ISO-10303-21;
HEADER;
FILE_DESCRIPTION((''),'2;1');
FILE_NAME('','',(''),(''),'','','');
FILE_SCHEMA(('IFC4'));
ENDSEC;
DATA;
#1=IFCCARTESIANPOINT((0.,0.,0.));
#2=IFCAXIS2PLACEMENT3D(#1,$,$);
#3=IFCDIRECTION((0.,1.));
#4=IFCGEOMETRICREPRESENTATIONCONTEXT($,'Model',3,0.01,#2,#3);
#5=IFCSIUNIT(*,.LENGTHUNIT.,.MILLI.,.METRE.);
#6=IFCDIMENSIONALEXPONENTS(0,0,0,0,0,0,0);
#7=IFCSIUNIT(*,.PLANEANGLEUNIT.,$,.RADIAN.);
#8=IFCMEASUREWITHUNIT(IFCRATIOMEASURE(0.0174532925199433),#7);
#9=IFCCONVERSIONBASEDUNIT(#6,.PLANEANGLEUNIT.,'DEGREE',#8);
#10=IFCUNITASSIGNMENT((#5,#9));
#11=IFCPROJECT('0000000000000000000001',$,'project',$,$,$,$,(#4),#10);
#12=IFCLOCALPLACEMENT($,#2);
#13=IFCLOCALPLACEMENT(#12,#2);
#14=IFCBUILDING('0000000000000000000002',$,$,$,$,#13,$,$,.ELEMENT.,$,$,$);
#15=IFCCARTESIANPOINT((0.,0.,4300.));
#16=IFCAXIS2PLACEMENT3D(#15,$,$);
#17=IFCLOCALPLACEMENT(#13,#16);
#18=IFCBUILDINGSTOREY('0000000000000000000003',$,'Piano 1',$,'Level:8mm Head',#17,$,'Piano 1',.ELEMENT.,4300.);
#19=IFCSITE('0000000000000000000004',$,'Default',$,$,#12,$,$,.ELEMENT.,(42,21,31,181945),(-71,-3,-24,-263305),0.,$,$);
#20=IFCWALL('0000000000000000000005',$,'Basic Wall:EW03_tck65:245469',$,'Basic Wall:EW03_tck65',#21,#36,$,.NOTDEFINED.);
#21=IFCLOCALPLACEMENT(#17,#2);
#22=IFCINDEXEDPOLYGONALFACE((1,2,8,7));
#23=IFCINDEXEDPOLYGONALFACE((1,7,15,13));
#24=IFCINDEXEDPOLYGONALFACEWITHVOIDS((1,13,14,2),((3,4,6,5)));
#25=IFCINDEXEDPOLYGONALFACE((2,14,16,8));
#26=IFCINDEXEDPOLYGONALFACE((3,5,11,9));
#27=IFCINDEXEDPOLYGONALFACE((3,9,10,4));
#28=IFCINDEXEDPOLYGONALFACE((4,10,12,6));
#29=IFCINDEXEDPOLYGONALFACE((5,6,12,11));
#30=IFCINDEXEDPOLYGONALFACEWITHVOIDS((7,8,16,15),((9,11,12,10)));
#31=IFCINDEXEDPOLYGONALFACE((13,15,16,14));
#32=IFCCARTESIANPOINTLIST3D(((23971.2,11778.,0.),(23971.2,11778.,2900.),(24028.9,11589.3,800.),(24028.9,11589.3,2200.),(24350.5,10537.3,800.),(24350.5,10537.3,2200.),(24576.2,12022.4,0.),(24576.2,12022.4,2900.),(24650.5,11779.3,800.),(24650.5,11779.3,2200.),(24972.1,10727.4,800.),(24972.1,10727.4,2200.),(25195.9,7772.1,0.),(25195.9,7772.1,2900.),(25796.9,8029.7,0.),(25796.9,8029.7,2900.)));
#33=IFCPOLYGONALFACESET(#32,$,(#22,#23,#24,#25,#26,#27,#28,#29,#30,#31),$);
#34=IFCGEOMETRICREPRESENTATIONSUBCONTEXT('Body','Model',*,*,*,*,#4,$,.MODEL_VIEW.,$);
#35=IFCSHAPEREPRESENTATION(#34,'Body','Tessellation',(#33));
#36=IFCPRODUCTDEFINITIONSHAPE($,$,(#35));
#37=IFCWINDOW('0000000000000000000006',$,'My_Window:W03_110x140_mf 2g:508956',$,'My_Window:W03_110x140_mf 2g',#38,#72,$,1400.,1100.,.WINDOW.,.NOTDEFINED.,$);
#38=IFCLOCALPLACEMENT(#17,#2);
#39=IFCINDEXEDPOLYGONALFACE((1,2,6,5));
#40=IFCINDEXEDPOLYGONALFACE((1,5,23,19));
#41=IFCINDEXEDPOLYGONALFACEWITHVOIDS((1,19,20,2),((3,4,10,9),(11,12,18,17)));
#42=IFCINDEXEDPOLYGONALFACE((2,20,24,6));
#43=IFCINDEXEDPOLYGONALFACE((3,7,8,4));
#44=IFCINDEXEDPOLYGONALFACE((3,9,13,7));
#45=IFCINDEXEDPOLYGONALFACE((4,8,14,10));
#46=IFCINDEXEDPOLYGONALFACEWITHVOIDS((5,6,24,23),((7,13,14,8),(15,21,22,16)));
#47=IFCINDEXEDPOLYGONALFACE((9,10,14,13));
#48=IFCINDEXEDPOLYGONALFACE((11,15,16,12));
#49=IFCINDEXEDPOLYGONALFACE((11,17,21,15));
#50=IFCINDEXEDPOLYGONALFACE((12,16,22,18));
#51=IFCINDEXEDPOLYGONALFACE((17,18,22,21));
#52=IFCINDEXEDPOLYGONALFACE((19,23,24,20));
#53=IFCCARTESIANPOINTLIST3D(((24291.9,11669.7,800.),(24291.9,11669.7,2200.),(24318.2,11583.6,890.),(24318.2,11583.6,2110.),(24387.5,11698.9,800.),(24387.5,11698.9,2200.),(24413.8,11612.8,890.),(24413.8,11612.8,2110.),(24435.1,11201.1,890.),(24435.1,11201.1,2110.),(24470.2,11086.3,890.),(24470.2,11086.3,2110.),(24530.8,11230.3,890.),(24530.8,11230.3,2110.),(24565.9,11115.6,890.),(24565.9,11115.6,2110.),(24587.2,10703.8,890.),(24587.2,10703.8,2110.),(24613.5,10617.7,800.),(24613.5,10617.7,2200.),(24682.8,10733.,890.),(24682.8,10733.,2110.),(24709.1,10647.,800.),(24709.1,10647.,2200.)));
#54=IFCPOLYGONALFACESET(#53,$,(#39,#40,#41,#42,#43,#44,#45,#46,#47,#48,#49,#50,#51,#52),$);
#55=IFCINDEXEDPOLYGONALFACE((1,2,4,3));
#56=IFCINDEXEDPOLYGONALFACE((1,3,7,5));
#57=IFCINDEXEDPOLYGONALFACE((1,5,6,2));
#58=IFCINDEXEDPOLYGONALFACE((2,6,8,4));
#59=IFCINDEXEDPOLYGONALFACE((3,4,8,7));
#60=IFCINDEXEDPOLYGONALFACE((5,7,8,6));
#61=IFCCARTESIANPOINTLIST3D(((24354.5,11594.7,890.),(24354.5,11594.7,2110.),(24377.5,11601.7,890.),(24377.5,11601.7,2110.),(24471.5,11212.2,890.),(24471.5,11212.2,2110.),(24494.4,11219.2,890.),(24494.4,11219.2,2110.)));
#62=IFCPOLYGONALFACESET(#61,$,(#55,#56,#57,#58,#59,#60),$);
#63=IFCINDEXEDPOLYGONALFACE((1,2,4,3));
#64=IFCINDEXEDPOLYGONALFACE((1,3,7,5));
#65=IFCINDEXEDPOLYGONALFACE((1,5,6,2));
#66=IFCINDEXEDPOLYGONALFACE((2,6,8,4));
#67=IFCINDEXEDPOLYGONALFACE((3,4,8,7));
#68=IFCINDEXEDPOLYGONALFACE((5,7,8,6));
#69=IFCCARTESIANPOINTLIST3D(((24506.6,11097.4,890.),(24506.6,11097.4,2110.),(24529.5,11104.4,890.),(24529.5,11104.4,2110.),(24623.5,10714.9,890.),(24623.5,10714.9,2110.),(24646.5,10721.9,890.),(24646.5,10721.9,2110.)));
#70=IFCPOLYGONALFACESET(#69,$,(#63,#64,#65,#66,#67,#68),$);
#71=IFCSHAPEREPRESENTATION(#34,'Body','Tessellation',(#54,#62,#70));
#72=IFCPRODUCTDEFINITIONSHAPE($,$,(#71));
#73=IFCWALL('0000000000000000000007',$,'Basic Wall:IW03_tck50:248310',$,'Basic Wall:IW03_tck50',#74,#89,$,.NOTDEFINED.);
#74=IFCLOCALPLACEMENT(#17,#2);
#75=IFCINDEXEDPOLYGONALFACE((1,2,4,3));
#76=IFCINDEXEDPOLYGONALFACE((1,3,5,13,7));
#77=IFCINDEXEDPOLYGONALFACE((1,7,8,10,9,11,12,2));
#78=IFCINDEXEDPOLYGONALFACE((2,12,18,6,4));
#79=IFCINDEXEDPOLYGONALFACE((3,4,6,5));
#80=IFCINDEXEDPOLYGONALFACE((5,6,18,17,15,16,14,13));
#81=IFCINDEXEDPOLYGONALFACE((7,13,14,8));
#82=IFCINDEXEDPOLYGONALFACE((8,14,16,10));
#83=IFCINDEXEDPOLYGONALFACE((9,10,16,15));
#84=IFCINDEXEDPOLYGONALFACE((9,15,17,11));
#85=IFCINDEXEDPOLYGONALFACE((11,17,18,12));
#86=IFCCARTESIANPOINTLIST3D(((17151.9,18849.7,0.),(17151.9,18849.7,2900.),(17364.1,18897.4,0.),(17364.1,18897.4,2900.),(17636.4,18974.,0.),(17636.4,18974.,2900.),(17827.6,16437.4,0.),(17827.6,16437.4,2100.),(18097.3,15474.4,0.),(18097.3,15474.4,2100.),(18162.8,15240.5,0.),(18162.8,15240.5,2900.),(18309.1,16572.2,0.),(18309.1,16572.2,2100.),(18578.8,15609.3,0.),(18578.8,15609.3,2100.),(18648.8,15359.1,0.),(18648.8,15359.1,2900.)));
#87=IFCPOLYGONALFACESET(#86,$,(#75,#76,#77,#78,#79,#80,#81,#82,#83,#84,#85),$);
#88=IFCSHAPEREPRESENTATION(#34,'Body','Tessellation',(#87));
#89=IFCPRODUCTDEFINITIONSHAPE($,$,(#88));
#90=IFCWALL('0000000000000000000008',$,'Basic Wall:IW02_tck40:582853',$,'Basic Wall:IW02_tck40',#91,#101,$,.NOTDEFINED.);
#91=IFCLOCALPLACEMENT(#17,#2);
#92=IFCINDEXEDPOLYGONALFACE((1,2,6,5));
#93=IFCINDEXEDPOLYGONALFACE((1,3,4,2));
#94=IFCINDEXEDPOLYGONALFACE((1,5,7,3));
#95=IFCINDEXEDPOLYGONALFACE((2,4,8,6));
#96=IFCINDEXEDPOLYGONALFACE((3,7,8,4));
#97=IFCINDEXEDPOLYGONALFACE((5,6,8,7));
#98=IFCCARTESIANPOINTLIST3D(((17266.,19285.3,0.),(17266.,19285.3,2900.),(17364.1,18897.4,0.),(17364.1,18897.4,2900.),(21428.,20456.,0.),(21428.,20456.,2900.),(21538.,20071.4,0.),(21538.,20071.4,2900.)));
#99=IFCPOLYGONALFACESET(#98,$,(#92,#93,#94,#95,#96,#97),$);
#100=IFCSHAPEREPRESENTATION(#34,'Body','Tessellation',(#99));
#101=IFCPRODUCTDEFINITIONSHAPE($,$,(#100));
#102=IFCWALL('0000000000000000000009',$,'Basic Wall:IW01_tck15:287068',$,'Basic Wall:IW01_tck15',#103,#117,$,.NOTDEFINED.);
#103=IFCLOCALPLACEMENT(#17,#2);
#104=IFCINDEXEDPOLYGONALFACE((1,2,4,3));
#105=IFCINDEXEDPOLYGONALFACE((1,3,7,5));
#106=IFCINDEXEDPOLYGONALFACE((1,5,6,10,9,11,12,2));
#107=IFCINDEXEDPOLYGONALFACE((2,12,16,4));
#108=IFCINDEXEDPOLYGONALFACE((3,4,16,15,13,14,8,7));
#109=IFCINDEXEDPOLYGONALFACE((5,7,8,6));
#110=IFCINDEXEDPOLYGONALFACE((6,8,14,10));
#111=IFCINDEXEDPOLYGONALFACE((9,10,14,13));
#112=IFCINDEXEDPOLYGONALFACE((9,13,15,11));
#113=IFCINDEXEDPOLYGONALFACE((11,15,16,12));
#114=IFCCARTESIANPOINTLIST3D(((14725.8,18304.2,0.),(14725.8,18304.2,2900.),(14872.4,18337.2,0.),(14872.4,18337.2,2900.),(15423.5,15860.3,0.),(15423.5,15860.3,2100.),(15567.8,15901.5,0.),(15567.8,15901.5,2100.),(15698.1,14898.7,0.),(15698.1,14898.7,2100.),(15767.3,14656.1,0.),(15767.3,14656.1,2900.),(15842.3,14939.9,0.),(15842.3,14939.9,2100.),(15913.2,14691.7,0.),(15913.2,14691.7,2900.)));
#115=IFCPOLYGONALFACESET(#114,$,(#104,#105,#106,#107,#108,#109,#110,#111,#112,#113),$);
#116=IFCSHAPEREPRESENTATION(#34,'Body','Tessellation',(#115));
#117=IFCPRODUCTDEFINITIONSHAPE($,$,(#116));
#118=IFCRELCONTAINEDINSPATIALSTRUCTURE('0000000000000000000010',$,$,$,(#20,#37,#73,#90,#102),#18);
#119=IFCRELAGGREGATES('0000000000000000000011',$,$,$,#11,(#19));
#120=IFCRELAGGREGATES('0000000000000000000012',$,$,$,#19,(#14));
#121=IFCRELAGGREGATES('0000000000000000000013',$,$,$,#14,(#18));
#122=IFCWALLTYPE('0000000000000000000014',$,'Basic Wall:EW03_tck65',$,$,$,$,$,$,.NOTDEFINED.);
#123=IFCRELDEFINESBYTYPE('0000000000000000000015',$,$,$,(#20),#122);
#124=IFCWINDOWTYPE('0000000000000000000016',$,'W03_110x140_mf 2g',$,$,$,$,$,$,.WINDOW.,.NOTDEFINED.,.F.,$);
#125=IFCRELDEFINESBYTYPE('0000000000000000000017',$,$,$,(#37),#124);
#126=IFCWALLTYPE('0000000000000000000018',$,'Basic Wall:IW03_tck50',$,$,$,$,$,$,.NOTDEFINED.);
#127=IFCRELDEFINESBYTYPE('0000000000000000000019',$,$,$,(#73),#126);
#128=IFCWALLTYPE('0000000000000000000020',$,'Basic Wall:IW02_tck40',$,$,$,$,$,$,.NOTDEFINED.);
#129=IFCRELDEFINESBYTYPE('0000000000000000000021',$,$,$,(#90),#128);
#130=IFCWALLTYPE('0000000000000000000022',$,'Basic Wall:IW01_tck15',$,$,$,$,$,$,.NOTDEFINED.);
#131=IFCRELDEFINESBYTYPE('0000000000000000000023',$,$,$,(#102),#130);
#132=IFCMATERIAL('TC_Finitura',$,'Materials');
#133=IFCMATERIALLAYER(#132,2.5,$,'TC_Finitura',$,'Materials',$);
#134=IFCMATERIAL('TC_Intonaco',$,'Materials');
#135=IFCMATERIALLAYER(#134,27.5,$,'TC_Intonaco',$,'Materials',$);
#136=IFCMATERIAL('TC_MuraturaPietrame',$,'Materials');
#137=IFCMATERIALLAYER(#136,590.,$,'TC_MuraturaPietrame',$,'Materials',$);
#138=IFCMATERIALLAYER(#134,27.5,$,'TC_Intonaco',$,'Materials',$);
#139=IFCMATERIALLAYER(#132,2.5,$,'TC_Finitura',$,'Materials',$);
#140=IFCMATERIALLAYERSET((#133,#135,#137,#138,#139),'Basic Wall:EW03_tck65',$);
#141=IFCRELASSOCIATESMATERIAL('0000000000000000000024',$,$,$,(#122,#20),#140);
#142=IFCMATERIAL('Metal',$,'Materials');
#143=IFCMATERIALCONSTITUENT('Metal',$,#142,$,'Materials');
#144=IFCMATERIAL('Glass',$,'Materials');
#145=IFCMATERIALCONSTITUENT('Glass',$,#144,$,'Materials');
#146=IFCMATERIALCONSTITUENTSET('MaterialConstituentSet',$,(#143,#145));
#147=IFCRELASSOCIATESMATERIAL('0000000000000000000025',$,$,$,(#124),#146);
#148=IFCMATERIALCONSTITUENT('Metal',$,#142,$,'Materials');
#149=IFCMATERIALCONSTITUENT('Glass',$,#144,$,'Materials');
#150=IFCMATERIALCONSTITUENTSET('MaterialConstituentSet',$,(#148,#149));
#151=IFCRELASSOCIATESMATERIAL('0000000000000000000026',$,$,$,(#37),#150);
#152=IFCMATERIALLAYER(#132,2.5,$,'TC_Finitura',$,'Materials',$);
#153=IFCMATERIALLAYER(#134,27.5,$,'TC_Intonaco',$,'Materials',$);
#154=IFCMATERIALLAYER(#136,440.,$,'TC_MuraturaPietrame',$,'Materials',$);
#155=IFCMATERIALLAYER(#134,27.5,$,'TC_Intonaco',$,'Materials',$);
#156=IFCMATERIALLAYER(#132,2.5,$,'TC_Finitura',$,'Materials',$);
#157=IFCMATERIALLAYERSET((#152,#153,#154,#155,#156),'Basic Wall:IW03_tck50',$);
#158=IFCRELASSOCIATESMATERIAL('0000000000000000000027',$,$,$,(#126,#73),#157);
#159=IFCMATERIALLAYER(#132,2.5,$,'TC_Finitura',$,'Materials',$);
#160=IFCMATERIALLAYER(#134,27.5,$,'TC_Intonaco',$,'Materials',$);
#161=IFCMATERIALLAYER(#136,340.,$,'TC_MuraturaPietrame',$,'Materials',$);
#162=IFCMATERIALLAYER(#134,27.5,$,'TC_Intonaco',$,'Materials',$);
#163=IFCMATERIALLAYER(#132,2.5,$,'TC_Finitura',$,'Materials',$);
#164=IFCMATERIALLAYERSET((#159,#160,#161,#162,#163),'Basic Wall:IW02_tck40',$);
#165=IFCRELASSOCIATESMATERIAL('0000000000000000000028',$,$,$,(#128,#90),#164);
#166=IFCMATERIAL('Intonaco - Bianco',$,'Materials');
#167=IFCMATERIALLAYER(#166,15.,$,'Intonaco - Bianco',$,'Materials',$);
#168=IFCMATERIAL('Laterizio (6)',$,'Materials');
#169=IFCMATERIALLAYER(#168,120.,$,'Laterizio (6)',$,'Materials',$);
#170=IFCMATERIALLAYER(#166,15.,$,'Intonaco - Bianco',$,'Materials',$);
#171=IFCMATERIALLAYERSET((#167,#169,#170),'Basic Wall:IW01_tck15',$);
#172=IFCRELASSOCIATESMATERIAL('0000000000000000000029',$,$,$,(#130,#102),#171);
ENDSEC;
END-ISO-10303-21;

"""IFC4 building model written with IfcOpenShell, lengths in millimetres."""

from ifc_helpers import new_model, entity, si_unit, converted_unit, direction, frame, frame_2d, origin, origin_2d_with_axis, place, context, subcontext, project, spatial, polyline, rectangle, outline, extrude, clip, bounded_halfspace, source, transform, mapped, material, layer, layer_set, layer_usage, constituent, constituent_set, type_object, type_shapes, element, fill, save


model = new_model("IFC4")

# Units and contexts
model_context = context("Model", 3, precision=0.01, world=origin(), true_north=direction((0.0, 1.0)))
body_context = subcontext(model_context, "Body", "Model", "MODEL_VIEW")
ifc_project = project(units=[si_unit("LENGTHUNIT", "METRE", prefix="MILLI"), converted_unit("PLANEANGLEUNIT", "DEGREE", entity("IfcRatioMeasure", 0.0174532925199433), si_unit("PLANEANGLEUNIT", "RADIAN"), dimensions=[0, 0, 0, 0, 0, 0, 0])], contexts=[model_context])

# Site, building, storey
site_placement = place(None, origin())
site = spatial("IfcSite", under=ifc_project, at=site_placement, Name="Default", CompositionType="ELEMENT", RefLatitude=(42, 21, 31, 181945), RefLongitude=(-71, -3, -24, -263305), RefElevation=0.0)
building_placement = place(site_placement, origin())
building = spatial("IfcBuilding", under=site, at=building_placement, CompositionType="ELEMENT")
storey_placement = place(building_placement, frame((0.0, 0.0, 4300.0)))
storey = spatial("IfcBuildingStorey", under=building, at=storey_placement, Name="Piano 1", ObjectType="Level:8mm Head", LongName="Piano 1", CompositionType="ELEMENT", Elevation=4300.0)

# Shared definitions
ifc_material_1 = material(Name="TC_Finitura", Category="Materials")
ifc_material_2 = material(Name="TC_Intonaco", Category="Materials")
ifc_material_3 = material(Name="TC_MuraturaPietrame", Category="Materials")

# Wall, opening, window
ifc_material_4 = material(Name="Metal", Category="Materials")
ifc_material_5 = material(Name="Glass", Category="Materials")
ifc_layer_1 = layer(ifc_material_1, 2.5, Name="TC_Finitura", Category="Materials")
ifc_layer_2 = layer(ifc_material_2, 27.5, Name="TC_Intonaco", Category="Materials")
ifc_layer_3 = layer(ifc_material_3, 590.0, Name="TC_MuraturaPietrame", Category="Materials")
ifc_layer_4 = layer(ifc_material_2, 27.5, Name="TC_Intonaco", Category="Materials")
ifc_layer_5 = layer(ifc_material_1, 2.5, Name="TC_Finitura", Category="Materials")
ifc_layer_set_1 = layer_set([ifc_layer_1, ifc_layer_2, ifc_layer_3, ifc_layer_4, ifc_layer_5], Name="Basic Wall:EW03_tck65")
ifc_layer_usage_1 = layer_usage(ifc_layer_set_1, "AXIS2", "NEGATIVE", 325.0)
wall_type_1 = type_object("IfcWallType", Name="Basic Wall:EW03_tck65", PredefinedType="NOTDEFINED", material=ifc_layer_set_1)
wall_1_placement = place(storey_placement, frame((24265.4, 11927.4, 0.0), z_axis=(0.0, 0.0, 1.0), x_axis=(0.292372, -0.956305, 0.0)))
wall_1 = element("IfcWall", 1, at=wall_1_placement, inside=storey, type_object=wall_type_1, material=ifc_layer_usage_1, Name="Basic Wall:EW03_tck65:245469", ObjectType="Basic Wall:EW03_tck65", PredefinedType="NOTDEFINED", context=body_context, shape_type="Clipping", body=[
    clip(extrude(outline(polyline([(4245.8, -325.0), (4175.2, 325.0), (0.0, 325.0), (56.9, -325.0), (1562.6, -325.0), (1713.2, -325.0), (3491.4, -325.0), (4245.8, -325.0)])), origin(), (0.0, 0.0, 1.0), 2900.0), bounded_halfspace(frame((56.9, -325.0, 2900.0), z_axis=(0.0, 0.0, -1.0), x_axis=(0.022514, 0.999747, 0.0)), True, frame((56.9, -325.0, 2900.0)), polyline([(0.0, 0.0), (1505.7, 0.0), (1656.3, 0.0), (3434.5, 0.0), (4188.9, 0.0), (4118.3, 650.0), (-56.9, 650.0), (0.0, 0.0)]))),
])
opening_1_placement = place(wall_1_placement, frame((254.2, -325.0, 800.0)))
opening_1 = element("IfcOpeningElement", 2, at=opening_1_placement, cuts=wall_1, ObjectType="Opening", PredefinedType="OPENING", context=body_context, shape_type="SweptSolid", body=[
    extrude(rectangle(XDim=1400.0, YDim=1100.0, at=frame_2d((700.0, 550.0), x_axis=(-1.0, 0.0))), frame((0.0, 0.0, 0.0), z_axis=(0.0, 1.0, 0.0), x_axis=(0.0, 0.0, 1.0)), (0.0, 0.0, 1.0), 650.0),
])
ifc_constituent_1 = constituent(ifc_material_4, Name="Metal", Category="Materials")
ifc_constituent_2 = constituent(ifc_material_5, Name="Glass", Category="Materials")
ifc_constituent_set_1 = constituent_set(constituents=[ifc_constituent_1, ifc_constituent_2], Name="MaterialConstituentSet")
ifc_constituent_3 = constituent(ifc_material_4, Name="Metal", Category="Materials")
ifc_constituent_4 = constituent(ifc_material_5, Name="Glass", Category="Materials")
ifc_constituent_set_2 = constituent_set(constituents=[ifc_constituent_3, ifc_constituent_4], Name="MaterialConstituentSet")
window_type_1 = type_object("IfcWindowType", Name="W03_110x140_mf 2g", ParameterTakesPrecedence=False, PartitioningType="NOTDEFINED", PredefinedType="WINDOW", material=ifc_constituent_set_2)
shared_shape_1 = source(origin(), body_context, "Body", "SweptSolid", [
    extrude(outline(polyline([(-550.0, -700.0), (550.0, -700.0), (550.0, 700.0), (-550.0, 700.0), (-550.0, -700.0)]), holes=[polyline([(-60.0, -610.0), (-460.0, -610.0), (-460.0, 610.0), (-60.0, 610.0), (-60.0, -610.0)]), polyline([(460.0, -610.0), (60.0, -610.0), (60.0, 610.0), (460.0, 610.0), (460.0, -610.0)])]), frame((550.0, 275.0, 700.0), z_axis=(0.0, 1.0, 0.0), x_axis=(1.0, 0.0, 0.0)), (0.0, 0.0, 1.0), 100.0),
    extrude(rectangle(XDim=24.0, YDim=400.0, at=origin_2d_with_axis()), frame((290.0, 325.0, 90.0), z_axis=(0.0, 0.0, 1.0), x_axis=(0.0, 1.0, 0.0)), (0.0, 0.0, 1.0), 1220.0),
    extrude(rectangle(XDim=24.0, YDim=400.0, at=frame_2d((0.0, 0.0), x_axis=(1.0, 0.0))), frame((810.0, 325.0, 90.0), z_axis=(0.0, 0.0, 1.0), x_axis=(0.0, 1.0, 0.0)), (0.0, 0.0, 1.0), 1220.0),
])
type_shapes(window_type_1, [shared_shape_1])
window_1_placement = place(opening_1_placement, origin())
window_1 = element("IfcWindow", 3, at=window_1_placement, inside=storey, type_object=window_type_1, material=ifc_constituent_set_1, Name="My_Window:W03_110x140_mf 2g:508956", ObjectType="My_Window:W03_110x140_mf 2g", OverallHeight=1400.0, OverallWidth=1100.0, PartitioningType="NOTDEFINED", PredefinedType="WINDOW", context=body_context, shape_type="MappedRepresentation", body=[
    mapped(shared_shape_1, transform((0.0, 0.0, 0.0), scale=1.0)),
])
fill(opening_1, window_1)

# Wall, opening
ifc_layer_6 = layer(ifc_material_1, 2.5, Name="TC_Finitura", Category="Materials")
ifc_layer_7 = layer(ifc_material_2, 27.5, Name="TC_Intonaco", Category="Materials")
ifc_layer_8 = layer(ifc_material_3, 440.0, Name="TC_MuraturaPietrame", Category="Materials")
ifc_layer_9 = layer(ifc_material_2, 27.5, Name="TC_Intonaco", Category="Materials")
ifc_layer_10 = layer(ifc_material_1, 2.5, Name="TC_Finitura", Category="Materials")
ifc_layer_set_2 = layer_set([ifc_layer_6, ifc_layer_7, ifc_layer_8, ifc_layer_9, ifc_layer_10], Name="Basic Wall:IW03_tck50")
ifc_layer_usage_2 = layer_usage(ifc_layer_set_2, "AXIS2", "NEGATIVE", 250.0)
wall_type_2 = type_object("IfcWallType", Name="Basic Wall:IW03_tck50", PredefinedType="NOTDEFINED", material=ifc_layer_set_2)
wall_2_placement = place(storey_placement, frame((17392.7, 18917.1, 0.0), z_axis=(0.0, 0.0, 1.0), x_axis=(0.269701, -0.962944, 0.0)))
wall_2 = element("IfcWall", 4, at=wall_2_placement, inside=storey, type_object=wall_type_2, material=ifc_layer_usage_2, Name="Basic Wall:IW03_tck50:248310", ObjectType="Basic Wall:IW03_tck50", PredefinedType="NOTDEFINED", context=body_context, shape_type="Clipping", body=[
    clip(extrude(outline(polyline([(0.0, -250.0), (3748.1, -250.0), (3765.0, 250.0), (11.0, 250.0), (11.3, -32.9), (0.0, -250.0)])), origin(), (0.0, 0.0, 1.0), 2900.0), bounded_halfspace(frame((0.0, -250.0, 2900.0), z_axis=(0.0, 0.0, -1.0), x_axis=(-0.001108, 0.999999, 0.0)), True, frame((0.0, -250.0, 2900.0)), polyline([(0.0, 0.0), (3748.1, 0.0), (3765.0, 500.0), (11.0, 500.0), (11.3, 217.1), (0.0, 0.0)]))),
])
opening_2_placement = place(wall_2_placement, frame((2505.1, -250.0, 0.0)))
element("IfcOpeningElement", 5, at=opening_2_placement, cuts=wall_2, ObjectType="Opening", PredefinedType="OPENING", context=body_context, shape_type="SweptSolid", body=[
    extrude(rectangle(XDim=2100.0, YDim=1000.0, at=frame_2d((1050.0, 500.0), x_axis=(1.0, 0.0))), frame((0.0, 0.0, 0.0), z_axis=(0.0, 1.0, 0.0), x_axis=(0.0, 0.0, 1.0)), (0.0, 0.0, 1.0), 500.0),
])
ifc_layer_11 = layer(ifc_material_1, 2.5, Name="TC_Finitura", Category="Materials")
ifc_layer_12 = layer(ifc_material_2, 27.5, Name="TC_Intonaco", Category="Materials")
ifc_layer_13 = layer(ifc_material_3, 340.0, Name="TC_MuraturaPietrame", Category="Materials")
ifc_layer_14 = layer(ifc_material_2, 27.5, Name="TC_Intonaco", Category="Materials")
ifc_layer_15 = layer(ifc_material_1, 2.5, Name="TC_Finitura", Category="Materials")
ifc_layer_set_3 = layer_set([ifc_layer_11, ifc_layer_12, ifc_layer_13, ifc_layer_14, ifc_layer_15], Name="Basic Wall:IW02_tck40")
wall_type_3 = type_object("IfcWallType", Name="Basic Wall:IW02_tck40", PredefinedType="NOTDEFINED", material=ifc_layer_set_3)

# Wall
ifc_layer_usage_3 = layer_usage(ifc_layer_set_3, "AXIS2", "NEGATIVE", 200.0)
wall_3_placement = place(storey_placement, frame((17309.9, 19089.9, 0.0), z_axis=(0.0, 0.0, 1.0), x_axis=(0.962644, 0.27077, 0.0)))
element("IfcWall", 6, at=wall_3_placement, inside=storey, type_object=wall_type_3, material=ifc_layer_usage_3, Name="Basic Wall:IW02_tck40:582853", ObjectType="Basic Wall:IW02_tck40", PredefinedType="NOTDEFINED", context=body_context, shape_type="Clipping", body=[
    clip(extrude(outline(polyline([(4335.9, -200.0), (4334.1, 200.0), (10.6, 200.0), (0.0, -200.0), (282.9, -200.0), (4335.9, -200.0)])), origin(), (0.0, 0.0, 1.0), 2900.0), bounded_halfspace(frame((0.0, -200.0, 2900.0), z_axis=(0.0, 0.0, -1.0), x_axis=(1.0, -0.000003, 0.0)), True, frame((0.0, -200.0, 2900.0)), polyline([(0.0, 0.0), (282.9, 0.0), (4335.9, 0.0), (4334.1, 400.0), (13.4, 400.0), (10.6, 400.0), (0.0, 0.0)]))),
])

# Wall, opening
ifc_material_6 = material(Name="Intonaco - Bianco", Category="Materials")
ifc_layer_16 = layer(ifc_material_6, 15.0, Name="Intonaco - Bianco", Category="Materials")
ifc_material_7 = material(Name="Laterizio (6)", Category="Materials")
ifc_layer_17 = layer(ifc_material_7, 120.0, Name="Laterizio (6)", Category="Materials")
ifc_layer_18 = layer(ifc_material_6, 15.0, Name="Intonaco - Bianco", Category="Materials")
ifc_layer_set_4 = layer_set([ifc_layer_16, ifc_layer_17, ifc_layer_18], Name="Basic Wall:IW01_tck15")
ifc_layer_usage_4 = layer_usage(ifc_layer_set_4, "AXIS2", "NEGATIVE", 75.0)
wall_type_4 = type_object("IfcWallType", Name="Basic Wall:IW01_tck15", PredefinedType="NOTDEFINED", material=ifc_layer_set_4)
wall_4_placement = place(storey_placement, frame((14797.9, 18324.8, 0.0), z_axis=(0.0, 0.0, 1.0), x_axis=(0.274538, -0.961576, 0.0)))
wall_4 = element("IfcWall", 7, at=wall_4_placement, inside=storey, type_object=wall_type_4, material=ifc_layer_usage_4, Name="Basic Wall:IW01_tck15:287068", ObjectType="Basic Wall:IW01_tck15", PredefinedType="NOTDEFINED", context=body_context, shape_type="Clipping", body=[
    clip(extrude(outline(polyline([(0.0, -75.0), (3793.9, -75.0), (3799.7, 75.0), (8.6, 75.0), (0.0, -75.0)])), origin(), (0.0, 0.0, 1.0), 2900.0), bounded_halfspace(frame((0.0, -75.0, 2900.0), z_axis=(0.0, 0.0, -1.0), x_axis=(0.003919, 0.999992, 0.0)), True, frame((0.0, -75.0, 2900.0)), polyline([(0.0, 0.0), (3793.9, 0.0), (3799.7, 150.0), (8.6, 150.0), (0.0, 0.0)]))),
])
opening_3_placement = place(wall_4_placement, frame((3541.6, 75.0, 0.0)))
element("IfcOpeningElement", 8, at=opening_3_placement, cuts=wall_4, ObjectType="Opening", PredefinedType="OPENING", context=body_context, shape_type="SweptSolid", body=[
    extrude(rectangle(XDim=2100.0, YDim=1000.0, at=frame_2d((1050.0, 500.0), x_axis=(1.0, 0.0))), frame((0.0, 0.0, 0.0), z_axis=(0.0, -1.0, 0.0), x_axis=(0.0, 0.0, 1.0)), (0.0, 0.0, 1.0), 150.0),
])

save(model, "model.ifc")
